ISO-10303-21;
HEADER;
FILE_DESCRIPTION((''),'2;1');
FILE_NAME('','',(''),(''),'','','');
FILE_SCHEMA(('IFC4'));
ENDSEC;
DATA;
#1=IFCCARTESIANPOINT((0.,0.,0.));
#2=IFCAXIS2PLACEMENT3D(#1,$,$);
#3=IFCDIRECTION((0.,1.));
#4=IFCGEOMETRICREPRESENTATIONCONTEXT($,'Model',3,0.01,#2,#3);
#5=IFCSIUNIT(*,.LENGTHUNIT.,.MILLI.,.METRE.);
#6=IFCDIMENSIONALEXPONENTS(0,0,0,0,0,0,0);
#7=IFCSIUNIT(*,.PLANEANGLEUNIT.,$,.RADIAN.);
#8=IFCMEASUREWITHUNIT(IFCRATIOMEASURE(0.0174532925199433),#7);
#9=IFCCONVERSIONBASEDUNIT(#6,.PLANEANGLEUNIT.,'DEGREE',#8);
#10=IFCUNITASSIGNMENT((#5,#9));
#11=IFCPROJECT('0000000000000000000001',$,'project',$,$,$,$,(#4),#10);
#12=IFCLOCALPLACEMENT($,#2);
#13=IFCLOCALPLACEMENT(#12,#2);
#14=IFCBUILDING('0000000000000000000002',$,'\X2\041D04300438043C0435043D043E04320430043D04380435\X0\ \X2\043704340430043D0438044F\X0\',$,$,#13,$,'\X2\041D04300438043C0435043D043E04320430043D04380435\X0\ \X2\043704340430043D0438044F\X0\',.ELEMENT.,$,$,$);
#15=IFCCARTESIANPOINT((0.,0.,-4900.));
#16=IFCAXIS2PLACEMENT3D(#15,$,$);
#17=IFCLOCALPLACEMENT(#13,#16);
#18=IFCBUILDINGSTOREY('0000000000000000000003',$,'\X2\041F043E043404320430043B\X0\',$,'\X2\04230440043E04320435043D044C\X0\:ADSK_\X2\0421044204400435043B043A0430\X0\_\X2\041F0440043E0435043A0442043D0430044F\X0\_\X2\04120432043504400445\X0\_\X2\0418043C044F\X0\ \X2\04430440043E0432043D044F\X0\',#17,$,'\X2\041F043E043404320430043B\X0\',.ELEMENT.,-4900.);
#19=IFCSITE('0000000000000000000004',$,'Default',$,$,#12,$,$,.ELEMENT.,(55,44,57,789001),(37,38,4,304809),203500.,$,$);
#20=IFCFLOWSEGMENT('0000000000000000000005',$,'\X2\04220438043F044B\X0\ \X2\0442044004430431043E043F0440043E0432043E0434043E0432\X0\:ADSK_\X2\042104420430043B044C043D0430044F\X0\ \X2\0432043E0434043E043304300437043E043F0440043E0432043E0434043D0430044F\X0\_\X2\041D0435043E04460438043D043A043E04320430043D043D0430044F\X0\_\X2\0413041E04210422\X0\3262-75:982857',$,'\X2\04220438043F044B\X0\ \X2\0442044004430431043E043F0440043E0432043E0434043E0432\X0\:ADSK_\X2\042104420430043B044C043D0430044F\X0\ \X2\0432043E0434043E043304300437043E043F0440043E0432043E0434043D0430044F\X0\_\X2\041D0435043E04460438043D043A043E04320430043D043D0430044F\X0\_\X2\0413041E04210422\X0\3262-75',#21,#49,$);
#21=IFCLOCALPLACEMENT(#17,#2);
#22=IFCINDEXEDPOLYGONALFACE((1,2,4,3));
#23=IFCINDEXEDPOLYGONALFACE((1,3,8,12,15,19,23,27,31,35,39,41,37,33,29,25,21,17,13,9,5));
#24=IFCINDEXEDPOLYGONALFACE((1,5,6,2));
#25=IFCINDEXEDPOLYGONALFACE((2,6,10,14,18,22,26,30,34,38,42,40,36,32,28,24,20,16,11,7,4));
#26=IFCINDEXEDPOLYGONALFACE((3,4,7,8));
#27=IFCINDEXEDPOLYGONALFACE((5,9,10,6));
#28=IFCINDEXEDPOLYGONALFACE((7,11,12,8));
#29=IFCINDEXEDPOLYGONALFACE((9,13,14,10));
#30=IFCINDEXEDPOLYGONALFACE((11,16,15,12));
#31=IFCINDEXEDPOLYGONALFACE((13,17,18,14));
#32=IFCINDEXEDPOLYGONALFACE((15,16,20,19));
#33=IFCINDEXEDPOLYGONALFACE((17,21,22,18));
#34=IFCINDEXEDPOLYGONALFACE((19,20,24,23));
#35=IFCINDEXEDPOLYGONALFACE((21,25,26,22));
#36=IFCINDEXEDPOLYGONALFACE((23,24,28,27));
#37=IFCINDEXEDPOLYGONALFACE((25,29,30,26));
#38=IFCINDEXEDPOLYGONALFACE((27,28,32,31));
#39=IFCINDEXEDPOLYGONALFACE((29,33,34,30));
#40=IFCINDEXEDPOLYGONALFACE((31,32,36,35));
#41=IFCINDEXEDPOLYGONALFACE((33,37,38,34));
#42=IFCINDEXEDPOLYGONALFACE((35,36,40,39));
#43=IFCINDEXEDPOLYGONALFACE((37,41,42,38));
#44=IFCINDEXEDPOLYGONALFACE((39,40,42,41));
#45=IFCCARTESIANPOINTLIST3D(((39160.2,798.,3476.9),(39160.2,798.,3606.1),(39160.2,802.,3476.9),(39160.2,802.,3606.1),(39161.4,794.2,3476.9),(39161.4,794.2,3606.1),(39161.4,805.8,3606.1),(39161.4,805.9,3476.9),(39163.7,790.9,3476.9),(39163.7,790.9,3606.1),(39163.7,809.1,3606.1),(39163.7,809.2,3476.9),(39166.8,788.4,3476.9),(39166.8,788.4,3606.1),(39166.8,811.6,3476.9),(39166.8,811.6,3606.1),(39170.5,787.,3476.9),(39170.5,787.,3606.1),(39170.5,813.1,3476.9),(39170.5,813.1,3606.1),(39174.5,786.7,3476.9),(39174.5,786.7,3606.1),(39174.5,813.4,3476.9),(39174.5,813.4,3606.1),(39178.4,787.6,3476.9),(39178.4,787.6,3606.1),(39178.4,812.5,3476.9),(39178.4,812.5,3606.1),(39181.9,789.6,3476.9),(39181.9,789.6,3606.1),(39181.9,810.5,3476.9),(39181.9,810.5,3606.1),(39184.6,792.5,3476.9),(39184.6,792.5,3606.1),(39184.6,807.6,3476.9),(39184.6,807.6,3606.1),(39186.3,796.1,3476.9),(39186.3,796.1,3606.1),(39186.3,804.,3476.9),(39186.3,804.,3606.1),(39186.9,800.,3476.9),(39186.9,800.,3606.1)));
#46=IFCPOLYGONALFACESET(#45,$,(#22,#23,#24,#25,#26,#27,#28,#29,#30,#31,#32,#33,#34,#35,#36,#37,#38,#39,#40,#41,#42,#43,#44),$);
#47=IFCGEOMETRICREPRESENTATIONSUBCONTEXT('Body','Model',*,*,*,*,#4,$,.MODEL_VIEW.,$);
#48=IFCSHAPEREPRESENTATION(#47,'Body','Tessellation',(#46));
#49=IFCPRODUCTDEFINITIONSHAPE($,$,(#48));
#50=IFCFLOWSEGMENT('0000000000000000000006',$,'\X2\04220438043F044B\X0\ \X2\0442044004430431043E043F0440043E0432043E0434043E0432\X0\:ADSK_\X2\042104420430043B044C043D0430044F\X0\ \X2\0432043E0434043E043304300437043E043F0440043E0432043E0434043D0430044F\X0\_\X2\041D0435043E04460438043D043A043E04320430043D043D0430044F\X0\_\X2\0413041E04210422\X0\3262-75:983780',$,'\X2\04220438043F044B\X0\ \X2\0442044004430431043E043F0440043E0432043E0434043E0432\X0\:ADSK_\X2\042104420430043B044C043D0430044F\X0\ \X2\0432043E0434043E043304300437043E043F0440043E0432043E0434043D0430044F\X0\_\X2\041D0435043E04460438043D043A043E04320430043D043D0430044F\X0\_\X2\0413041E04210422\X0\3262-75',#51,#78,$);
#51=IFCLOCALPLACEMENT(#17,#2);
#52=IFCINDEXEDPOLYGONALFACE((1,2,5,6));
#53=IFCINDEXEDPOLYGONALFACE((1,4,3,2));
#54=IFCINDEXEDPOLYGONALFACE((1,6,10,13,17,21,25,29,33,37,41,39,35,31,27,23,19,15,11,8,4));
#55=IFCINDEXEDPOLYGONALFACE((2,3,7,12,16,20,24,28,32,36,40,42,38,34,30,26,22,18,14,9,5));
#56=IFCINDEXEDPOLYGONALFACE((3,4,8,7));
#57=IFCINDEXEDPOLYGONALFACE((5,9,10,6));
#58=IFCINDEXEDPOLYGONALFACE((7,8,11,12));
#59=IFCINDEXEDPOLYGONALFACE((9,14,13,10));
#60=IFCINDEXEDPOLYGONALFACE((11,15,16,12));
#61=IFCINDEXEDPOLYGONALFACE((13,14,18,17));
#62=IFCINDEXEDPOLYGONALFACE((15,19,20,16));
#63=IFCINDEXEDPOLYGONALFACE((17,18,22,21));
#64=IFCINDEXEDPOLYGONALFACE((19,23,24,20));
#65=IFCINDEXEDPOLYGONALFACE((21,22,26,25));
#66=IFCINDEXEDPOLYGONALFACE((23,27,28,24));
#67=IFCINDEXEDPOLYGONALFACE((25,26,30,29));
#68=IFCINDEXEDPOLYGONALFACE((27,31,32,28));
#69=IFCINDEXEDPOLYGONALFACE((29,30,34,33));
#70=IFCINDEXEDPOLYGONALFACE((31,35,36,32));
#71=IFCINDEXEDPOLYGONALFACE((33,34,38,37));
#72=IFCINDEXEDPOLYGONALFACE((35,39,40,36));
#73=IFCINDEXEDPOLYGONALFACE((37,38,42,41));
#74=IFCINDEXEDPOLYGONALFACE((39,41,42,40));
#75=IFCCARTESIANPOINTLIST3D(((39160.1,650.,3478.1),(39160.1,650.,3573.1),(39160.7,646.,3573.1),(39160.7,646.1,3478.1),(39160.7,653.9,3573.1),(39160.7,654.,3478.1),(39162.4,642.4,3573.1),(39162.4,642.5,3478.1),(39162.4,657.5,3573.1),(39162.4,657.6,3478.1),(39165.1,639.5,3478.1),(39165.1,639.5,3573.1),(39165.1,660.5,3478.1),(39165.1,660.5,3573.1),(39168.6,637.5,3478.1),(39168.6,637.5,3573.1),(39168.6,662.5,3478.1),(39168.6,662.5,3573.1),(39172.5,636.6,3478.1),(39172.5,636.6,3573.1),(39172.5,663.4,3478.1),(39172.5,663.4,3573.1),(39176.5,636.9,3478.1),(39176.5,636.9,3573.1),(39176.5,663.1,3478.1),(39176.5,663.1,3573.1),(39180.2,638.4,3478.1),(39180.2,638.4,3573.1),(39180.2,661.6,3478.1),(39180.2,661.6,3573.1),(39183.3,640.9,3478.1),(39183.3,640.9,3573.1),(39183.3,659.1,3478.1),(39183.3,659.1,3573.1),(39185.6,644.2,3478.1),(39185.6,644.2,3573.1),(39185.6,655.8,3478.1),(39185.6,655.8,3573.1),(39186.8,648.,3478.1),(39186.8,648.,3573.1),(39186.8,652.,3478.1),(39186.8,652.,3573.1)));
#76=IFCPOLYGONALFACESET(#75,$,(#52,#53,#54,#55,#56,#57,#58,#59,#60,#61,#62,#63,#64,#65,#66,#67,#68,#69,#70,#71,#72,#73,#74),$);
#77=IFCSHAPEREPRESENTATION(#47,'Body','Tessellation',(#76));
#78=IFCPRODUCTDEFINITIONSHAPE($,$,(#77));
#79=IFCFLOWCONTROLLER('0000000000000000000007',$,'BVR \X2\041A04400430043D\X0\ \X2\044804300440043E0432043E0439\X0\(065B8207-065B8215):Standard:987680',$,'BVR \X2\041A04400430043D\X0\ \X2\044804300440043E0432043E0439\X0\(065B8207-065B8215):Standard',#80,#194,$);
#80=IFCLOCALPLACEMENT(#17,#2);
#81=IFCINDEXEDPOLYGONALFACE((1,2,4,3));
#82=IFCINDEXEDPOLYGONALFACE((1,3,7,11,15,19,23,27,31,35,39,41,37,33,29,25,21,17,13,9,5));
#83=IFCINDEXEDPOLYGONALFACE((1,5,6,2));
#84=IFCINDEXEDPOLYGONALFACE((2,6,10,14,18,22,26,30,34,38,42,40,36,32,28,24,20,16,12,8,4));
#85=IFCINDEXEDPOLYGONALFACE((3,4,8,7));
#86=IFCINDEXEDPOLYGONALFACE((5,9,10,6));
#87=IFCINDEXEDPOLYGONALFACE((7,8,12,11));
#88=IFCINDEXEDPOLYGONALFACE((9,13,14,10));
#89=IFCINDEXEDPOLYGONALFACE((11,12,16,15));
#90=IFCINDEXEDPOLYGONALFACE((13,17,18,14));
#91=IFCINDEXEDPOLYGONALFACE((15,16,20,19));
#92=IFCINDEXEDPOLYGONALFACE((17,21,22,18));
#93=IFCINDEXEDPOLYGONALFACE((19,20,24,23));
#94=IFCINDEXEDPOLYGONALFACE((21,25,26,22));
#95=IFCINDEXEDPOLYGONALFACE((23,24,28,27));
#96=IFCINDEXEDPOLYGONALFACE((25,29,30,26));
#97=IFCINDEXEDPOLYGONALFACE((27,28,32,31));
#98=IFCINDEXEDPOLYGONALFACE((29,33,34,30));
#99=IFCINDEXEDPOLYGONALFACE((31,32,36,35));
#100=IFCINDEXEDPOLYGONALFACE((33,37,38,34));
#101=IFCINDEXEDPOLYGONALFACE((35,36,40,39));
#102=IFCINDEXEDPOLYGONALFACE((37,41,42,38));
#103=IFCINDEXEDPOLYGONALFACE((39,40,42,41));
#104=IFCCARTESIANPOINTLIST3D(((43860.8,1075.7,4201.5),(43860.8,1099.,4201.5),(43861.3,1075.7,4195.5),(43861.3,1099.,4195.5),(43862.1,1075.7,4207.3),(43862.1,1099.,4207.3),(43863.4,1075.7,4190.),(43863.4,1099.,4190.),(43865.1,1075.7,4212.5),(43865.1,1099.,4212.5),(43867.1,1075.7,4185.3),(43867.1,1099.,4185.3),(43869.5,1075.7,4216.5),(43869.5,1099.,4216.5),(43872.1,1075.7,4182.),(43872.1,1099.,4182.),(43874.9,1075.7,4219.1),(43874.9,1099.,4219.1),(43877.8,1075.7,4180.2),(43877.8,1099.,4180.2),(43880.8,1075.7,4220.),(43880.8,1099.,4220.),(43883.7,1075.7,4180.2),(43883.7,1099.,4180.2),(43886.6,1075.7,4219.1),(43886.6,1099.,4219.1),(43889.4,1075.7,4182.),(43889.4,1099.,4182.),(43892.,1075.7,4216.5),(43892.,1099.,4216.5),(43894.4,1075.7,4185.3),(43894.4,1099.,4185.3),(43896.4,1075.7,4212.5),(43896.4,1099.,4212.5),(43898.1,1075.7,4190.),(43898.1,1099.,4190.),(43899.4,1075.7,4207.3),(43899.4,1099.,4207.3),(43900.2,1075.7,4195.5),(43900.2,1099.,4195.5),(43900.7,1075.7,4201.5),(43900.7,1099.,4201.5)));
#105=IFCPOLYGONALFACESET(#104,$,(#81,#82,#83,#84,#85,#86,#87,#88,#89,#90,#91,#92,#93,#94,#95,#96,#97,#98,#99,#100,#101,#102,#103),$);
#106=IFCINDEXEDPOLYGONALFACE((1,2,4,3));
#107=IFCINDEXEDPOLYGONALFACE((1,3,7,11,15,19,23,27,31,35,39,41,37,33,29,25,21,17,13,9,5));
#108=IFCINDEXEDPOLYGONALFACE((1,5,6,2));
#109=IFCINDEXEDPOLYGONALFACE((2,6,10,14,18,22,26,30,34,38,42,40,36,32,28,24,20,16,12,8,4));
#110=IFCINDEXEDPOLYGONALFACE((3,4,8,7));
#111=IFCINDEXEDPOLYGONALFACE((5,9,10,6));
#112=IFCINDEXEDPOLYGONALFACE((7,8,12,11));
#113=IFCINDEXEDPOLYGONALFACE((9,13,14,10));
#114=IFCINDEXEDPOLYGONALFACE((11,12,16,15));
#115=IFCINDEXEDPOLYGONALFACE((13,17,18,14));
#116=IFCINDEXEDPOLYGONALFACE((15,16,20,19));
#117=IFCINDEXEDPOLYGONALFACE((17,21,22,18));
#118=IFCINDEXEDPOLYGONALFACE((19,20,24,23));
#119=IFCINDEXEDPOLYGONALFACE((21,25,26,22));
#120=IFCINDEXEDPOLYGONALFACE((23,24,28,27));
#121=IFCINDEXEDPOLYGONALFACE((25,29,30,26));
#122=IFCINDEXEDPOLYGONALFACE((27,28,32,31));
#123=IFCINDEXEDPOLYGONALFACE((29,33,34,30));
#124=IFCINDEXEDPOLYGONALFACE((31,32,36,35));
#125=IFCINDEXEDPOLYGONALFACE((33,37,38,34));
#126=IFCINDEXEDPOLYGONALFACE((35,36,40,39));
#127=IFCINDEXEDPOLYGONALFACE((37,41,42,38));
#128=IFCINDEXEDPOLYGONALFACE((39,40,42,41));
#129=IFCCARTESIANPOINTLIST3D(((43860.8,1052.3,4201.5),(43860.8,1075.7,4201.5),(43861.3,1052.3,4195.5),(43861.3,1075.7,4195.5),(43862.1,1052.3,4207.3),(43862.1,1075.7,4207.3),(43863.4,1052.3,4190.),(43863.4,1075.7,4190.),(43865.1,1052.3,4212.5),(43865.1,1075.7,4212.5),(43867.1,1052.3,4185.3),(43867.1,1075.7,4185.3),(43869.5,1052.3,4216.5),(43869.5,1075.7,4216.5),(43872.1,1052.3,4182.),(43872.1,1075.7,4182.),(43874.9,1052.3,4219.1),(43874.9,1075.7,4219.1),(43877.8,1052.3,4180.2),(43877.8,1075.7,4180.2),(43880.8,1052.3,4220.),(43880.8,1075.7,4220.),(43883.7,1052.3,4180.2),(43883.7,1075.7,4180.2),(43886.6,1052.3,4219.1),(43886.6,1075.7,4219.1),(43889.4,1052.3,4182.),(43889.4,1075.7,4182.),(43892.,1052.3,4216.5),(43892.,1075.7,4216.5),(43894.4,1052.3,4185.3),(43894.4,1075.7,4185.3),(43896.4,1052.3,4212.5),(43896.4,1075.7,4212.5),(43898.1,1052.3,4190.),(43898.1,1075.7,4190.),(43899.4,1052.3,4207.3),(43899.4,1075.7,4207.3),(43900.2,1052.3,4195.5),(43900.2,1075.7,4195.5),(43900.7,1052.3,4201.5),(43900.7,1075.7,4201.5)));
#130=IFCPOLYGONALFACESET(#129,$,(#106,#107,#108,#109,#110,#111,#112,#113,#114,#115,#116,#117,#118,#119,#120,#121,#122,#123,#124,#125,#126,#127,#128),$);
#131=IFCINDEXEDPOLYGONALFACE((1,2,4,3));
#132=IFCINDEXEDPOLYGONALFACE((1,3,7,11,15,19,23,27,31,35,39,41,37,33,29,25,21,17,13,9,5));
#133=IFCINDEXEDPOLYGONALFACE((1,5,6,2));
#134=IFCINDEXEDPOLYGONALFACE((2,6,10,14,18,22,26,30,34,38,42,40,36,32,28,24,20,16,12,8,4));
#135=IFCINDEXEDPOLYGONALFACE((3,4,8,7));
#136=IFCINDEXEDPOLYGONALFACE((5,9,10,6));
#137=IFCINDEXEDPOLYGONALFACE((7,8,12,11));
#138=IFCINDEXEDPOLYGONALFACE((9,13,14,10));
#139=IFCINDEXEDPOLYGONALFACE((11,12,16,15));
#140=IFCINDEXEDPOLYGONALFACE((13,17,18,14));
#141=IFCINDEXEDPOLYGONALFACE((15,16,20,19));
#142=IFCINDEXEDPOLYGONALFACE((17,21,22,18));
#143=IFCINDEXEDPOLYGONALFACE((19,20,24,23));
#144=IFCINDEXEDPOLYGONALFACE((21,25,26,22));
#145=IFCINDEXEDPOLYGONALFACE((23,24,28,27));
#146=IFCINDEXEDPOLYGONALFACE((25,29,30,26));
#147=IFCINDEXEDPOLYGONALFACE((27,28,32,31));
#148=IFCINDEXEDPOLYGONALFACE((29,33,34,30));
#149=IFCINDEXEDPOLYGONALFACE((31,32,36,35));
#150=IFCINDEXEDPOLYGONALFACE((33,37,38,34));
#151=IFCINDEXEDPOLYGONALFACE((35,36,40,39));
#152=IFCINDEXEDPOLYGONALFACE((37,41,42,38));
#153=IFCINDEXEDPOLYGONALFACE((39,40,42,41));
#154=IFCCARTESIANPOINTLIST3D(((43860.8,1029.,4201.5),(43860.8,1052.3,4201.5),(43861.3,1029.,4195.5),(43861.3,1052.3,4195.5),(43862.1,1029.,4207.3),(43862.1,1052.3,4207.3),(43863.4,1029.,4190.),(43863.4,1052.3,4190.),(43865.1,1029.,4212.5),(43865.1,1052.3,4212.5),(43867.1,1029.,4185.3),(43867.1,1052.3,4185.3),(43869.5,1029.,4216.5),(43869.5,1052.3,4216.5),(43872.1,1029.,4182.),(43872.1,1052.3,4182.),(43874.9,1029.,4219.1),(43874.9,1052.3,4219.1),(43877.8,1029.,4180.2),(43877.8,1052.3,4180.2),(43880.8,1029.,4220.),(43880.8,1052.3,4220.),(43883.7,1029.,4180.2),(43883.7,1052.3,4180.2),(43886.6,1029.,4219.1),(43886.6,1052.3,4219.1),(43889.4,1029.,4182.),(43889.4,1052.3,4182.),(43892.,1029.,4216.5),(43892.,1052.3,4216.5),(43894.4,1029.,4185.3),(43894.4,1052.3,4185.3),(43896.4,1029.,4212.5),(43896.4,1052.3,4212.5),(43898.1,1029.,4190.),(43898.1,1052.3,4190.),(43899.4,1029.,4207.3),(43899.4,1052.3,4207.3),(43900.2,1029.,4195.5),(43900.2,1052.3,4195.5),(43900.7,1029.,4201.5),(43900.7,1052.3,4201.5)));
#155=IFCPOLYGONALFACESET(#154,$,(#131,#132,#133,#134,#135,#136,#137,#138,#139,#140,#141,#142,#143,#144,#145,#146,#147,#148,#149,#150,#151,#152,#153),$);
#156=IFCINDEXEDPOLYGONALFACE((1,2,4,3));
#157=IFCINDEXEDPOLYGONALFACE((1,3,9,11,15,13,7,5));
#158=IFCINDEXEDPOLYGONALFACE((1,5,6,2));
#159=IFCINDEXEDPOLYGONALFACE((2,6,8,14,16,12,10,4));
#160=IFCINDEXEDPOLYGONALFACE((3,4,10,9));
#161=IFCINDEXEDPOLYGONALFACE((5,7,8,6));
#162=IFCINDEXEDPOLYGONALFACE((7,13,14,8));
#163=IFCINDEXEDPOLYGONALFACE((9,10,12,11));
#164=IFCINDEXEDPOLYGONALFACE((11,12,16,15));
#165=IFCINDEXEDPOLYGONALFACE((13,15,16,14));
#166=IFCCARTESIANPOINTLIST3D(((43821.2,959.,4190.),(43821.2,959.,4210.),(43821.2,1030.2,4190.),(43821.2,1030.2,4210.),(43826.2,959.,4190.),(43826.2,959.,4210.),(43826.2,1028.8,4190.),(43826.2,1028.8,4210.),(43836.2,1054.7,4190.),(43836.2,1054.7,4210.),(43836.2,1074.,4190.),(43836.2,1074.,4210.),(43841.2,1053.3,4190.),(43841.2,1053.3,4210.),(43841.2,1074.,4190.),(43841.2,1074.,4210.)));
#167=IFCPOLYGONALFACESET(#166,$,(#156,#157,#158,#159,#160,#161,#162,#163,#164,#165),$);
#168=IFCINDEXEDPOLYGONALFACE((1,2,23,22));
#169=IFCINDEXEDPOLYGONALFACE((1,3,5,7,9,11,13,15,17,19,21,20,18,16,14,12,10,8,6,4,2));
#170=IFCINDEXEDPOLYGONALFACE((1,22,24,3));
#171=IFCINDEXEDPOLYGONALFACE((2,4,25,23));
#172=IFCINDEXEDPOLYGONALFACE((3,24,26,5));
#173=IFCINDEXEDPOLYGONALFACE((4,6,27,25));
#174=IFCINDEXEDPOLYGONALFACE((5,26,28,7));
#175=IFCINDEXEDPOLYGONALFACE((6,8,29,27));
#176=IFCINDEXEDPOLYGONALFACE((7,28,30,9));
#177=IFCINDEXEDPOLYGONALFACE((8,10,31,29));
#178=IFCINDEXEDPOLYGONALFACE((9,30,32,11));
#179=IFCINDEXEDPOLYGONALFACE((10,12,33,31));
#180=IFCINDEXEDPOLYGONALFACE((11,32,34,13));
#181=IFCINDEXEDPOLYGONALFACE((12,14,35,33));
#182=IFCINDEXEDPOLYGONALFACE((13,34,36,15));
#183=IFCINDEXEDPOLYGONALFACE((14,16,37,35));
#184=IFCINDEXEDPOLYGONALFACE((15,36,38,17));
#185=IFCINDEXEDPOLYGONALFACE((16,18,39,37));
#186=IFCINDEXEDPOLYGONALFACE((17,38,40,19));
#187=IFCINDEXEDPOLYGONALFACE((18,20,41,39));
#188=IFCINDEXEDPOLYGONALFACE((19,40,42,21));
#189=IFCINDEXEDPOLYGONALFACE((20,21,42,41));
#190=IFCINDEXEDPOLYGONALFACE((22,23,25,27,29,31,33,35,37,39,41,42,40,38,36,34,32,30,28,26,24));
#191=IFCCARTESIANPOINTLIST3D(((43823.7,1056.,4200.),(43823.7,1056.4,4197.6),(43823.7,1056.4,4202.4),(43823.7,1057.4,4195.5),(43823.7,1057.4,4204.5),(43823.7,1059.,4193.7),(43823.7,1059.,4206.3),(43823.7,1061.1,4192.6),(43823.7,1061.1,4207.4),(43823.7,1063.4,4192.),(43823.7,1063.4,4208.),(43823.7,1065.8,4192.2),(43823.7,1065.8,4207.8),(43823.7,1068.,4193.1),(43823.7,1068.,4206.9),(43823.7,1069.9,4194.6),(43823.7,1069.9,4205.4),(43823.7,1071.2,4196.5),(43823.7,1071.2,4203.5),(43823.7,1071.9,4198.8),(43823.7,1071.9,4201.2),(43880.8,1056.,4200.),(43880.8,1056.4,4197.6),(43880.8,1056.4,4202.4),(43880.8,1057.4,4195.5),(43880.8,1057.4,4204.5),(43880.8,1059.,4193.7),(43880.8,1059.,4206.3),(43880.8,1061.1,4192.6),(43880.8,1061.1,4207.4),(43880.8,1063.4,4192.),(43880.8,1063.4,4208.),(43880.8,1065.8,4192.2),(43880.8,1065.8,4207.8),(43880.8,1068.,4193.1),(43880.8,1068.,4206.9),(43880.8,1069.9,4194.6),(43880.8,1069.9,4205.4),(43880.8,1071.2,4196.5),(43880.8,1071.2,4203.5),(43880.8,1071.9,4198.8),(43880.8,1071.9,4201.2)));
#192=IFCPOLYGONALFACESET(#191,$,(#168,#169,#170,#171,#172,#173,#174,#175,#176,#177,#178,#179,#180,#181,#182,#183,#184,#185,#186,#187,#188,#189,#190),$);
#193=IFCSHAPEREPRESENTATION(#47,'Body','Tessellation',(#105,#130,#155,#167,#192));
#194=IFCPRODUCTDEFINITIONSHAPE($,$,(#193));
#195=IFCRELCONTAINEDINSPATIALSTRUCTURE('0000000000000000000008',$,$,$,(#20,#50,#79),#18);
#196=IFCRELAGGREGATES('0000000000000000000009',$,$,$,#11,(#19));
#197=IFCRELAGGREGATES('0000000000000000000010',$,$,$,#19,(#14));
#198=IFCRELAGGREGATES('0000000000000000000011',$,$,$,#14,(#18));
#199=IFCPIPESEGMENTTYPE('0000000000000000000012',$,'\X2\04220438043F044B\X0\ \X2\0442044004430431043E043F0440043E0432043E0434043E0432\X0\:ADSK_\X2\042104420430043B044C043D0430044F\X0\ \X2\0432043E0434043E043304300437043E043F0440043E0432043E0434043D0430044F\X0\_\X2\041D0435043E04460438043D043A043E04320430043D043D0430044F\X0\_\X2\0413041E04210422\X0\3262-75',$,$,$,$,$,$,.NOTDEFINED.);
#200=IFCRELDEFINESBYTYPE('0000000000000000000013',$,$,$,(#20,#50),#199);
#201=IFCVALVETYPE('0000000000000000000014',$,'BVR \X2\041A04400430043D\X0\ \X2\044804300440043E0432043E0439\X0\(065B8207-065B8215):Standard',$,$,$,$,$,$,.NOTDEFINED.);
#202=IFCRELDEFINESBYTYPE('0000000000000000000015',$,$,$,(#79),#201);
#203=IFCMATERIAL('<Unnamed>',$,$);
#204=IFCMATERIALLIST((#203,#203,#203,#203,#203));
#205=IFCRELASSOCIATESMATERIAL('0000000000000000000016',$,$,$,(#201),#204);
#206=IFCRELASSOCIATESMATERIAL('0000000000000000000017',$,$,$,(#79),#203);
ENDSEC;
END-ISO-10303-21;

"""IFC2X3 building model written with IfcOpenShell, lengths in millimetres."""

from ifc_helpers import new_model, entity, si_unit, converted_unit, direction, frame, origin, origin_2d_with_axis, place, context, subcontext, project, spatial, polyline, circle, outline, extrude, source, transform, mapped, material, material_list, type_object, type_shapes, element, save


model = new_model("IFC2X3")

# Units and contexts
model_context = context("Model", 3, precision=0.01, world=origin(), true_north=direction((0.0, 1.0)))
body_context = subcontext(model_context, "Body", "Model", "MODEL_VIEW")
ifc_project = project(units=[si_unit("LENGTHUNIT", "METRE", prefix="MILLI"), converted_unit("PLANEANGLEUNIT", "DEGREE", entity("IfcRatioMeasure", 0.0174532925199433), si_unit("PLANEANGLEUNIT", "RADIAN"), dimensions=[0, 0, 0, 0, 0, 0, 0])], contexts=[model_context])

# Site, building, storey
site_placement = place(None, origin())
site = spatial("IfcSite", under=ifc_project, at=site_placement, Name="Default", CompositionType="ELEMENT", RefLatitude=(55, 44, 57, 789001), RefLongitude=(37, 38, 4, 304809), RefElevation=203500.0)
building_placement = place(site_placement, origin())
building = spatial("IfcBuilding", under=site, at=building_placement, Name="Наименование здания", LongName="Наименование здания", CompositionType="ELEMENT")
storey_placement = place(building_placement, frame((0.0, 0.0, -4900.0)))
storey = spatial("IfcBuildingStorey", under=building, at=storey_placement, Name="Подвал", ObjectType="Уровень:ADSK_Стрелка_Проектная_Вверх_Имя уровня", LongName="Подвал", CompositionType="ELEMENT", Elevation=-4900.0)

# Flow segments
pipe_segment_type = type_object("IfcPipeSegmentType", Name="Типы трубопроводов:ADSK_Стальная водогазопроводная_Неоцинкованная_ГОСТ3262-75", PredefinedType="NOTDEFINED")
flow_segment_1_placement = place(storey_placement, frame((39158.5, 785.0, 3476.9)))
element("IfcFlowSegment", 1, at=flow_segment_1_placement, inside=storey, type_object=pipe_segment_type, Name="Типы трубопроводов:ADSK_Стальная водогазопроводная_Неоцинкованная_ГОСТ3262-75:982857", ObjectType="Типы трубопроводов:ADSK_Стальная водогазопроводная_Неоцинкованная_ГОСТ3262-75", context=body_context, shape_type="SweptSolid", body=[
    extrude(circle(Radius=13.4, at=origin_2d_with_axis()), frame((15.0, 15.0, 0.0), z_axis=(0.0, -0.000074, 1.0), x_axis=(1.0, 0.0, 0.0)), (0.0, 0.0, 1.0), 129.2),
])
flow_segment_2_placement = place(storey_placement, frame((39158.5, 635.0, 3478.1)))
element("IfcFlowSegment", 2, at=flow_segment_2_placement, inside=storey, type_object=pipe_segment_type, Name="Типы трубопроводов:ADSK_Стальная водогазопроводная_Неоцинкованная_ГОСТ3262-75:983780", ObjectType="Типы трубопроводов:ADSK_Стальная водогазопроводная_Неоцинкованная_ГОСТ3262-75", context=body_context, shape_type="SweptSolid", body=[
    extrude(circle(Radius=13.4, at=origin_2d_with_axis()), frame((15.0, 15.0, 0.0), z_axis=(0.0, -0.000144, 1.0), x_axis=(-1.0, 0.0, 0.0)), (0.0, 0.0, 1.0), 95.0),
])

# Flow controller
ifc_material = material(Name="<Unnamed>")
ifc_material_list_1 = material_list([ifc_material, ifc_material, ifc_material, ifc_material, ifc_material])
valve_type_1 = type_object("IfcValveType", Name="BVR Кран шаровой(065B8207-065B8215):Standard", PredefinedType="NOTDEFINED", material=ifc_material_list_1)
shared_shape_1 = source(origin(), body_context, "Body", "SweptSolid", [
    extrude(circle(Radius=20.0, at=origin_2d_with_axis()), frame((-35.0, 0.0, 0.0), z_axis=(1.0, 0.0, 0.0), x_axis=(0.0, 1.0, 0.0)), (0.0, 0.0, 1.0), 23.3),
    extrude(circle(Radius=20.0, at=origin_2d_with_axis()), frame((-11.7, 0.0, 0.0), z_axis=(1.0, 0.0, 0.0), x_axis=(0.0, 1.0, 0.0)), (0.0, 0.0, 1.0), 23.3),
    extrude(circle(Radius=20.0, at=origin_2d_with_axis()), frame((11.7, 0.0, 0.0), z_axis=(1.0, 0.0, 0.0), x_axis=(0.0, 1.0, 0.0)), (0.0, 0.0, 1.0), 23.3),
    extrude(outline(polyline([(-44.9, -5.0), (-44.9, -10.0), (-24.2, -10.0), (0.3, 5.0), (70.1, 5.0), (70.1, 10.0), (-1.1, 10.0), (-25.6, -5.0), (-44.9, -5.0)])), frame((34.9, -10.0, 49.5), z_axis=(0.0, -1.0, 0.0), x_axis=(1.0, 0.0, 0.0)), (0.0, 0.0, -1.0), 20.0),
    extrude(circle(Radius=8.0, at=origin_2d_with_axis()), origin(), (0.0, 0.0, 1.0), 57.0),
])
type_shapes(valve_type_1, [shared_shape_1])
flow_controller_1_placement = place(storey_placement, frame((43880.8, 1064.0, 4200.0), z_axis=(-1.0, 0.0, 0.0), x_axis=(0.0, -1.0, 0.0)))
element("IfcFlowController", 3, at=flow_controller_1_placement, inside=storey, type_object=valve_type_1, material=ifc_material, Name="BVR Кран шаровой(065B8207-065B8215):Standard:987680", ObjectType="BVR Кран шаровой(065B8207-065B8215):Standard", context=body_context, shape_type="MappedRepresentation", body=[
    mapped(shared_shape_1, transform((0.0, 0.0, 0.0), scale=1.0)),
])

save(model, "model.ifc")
